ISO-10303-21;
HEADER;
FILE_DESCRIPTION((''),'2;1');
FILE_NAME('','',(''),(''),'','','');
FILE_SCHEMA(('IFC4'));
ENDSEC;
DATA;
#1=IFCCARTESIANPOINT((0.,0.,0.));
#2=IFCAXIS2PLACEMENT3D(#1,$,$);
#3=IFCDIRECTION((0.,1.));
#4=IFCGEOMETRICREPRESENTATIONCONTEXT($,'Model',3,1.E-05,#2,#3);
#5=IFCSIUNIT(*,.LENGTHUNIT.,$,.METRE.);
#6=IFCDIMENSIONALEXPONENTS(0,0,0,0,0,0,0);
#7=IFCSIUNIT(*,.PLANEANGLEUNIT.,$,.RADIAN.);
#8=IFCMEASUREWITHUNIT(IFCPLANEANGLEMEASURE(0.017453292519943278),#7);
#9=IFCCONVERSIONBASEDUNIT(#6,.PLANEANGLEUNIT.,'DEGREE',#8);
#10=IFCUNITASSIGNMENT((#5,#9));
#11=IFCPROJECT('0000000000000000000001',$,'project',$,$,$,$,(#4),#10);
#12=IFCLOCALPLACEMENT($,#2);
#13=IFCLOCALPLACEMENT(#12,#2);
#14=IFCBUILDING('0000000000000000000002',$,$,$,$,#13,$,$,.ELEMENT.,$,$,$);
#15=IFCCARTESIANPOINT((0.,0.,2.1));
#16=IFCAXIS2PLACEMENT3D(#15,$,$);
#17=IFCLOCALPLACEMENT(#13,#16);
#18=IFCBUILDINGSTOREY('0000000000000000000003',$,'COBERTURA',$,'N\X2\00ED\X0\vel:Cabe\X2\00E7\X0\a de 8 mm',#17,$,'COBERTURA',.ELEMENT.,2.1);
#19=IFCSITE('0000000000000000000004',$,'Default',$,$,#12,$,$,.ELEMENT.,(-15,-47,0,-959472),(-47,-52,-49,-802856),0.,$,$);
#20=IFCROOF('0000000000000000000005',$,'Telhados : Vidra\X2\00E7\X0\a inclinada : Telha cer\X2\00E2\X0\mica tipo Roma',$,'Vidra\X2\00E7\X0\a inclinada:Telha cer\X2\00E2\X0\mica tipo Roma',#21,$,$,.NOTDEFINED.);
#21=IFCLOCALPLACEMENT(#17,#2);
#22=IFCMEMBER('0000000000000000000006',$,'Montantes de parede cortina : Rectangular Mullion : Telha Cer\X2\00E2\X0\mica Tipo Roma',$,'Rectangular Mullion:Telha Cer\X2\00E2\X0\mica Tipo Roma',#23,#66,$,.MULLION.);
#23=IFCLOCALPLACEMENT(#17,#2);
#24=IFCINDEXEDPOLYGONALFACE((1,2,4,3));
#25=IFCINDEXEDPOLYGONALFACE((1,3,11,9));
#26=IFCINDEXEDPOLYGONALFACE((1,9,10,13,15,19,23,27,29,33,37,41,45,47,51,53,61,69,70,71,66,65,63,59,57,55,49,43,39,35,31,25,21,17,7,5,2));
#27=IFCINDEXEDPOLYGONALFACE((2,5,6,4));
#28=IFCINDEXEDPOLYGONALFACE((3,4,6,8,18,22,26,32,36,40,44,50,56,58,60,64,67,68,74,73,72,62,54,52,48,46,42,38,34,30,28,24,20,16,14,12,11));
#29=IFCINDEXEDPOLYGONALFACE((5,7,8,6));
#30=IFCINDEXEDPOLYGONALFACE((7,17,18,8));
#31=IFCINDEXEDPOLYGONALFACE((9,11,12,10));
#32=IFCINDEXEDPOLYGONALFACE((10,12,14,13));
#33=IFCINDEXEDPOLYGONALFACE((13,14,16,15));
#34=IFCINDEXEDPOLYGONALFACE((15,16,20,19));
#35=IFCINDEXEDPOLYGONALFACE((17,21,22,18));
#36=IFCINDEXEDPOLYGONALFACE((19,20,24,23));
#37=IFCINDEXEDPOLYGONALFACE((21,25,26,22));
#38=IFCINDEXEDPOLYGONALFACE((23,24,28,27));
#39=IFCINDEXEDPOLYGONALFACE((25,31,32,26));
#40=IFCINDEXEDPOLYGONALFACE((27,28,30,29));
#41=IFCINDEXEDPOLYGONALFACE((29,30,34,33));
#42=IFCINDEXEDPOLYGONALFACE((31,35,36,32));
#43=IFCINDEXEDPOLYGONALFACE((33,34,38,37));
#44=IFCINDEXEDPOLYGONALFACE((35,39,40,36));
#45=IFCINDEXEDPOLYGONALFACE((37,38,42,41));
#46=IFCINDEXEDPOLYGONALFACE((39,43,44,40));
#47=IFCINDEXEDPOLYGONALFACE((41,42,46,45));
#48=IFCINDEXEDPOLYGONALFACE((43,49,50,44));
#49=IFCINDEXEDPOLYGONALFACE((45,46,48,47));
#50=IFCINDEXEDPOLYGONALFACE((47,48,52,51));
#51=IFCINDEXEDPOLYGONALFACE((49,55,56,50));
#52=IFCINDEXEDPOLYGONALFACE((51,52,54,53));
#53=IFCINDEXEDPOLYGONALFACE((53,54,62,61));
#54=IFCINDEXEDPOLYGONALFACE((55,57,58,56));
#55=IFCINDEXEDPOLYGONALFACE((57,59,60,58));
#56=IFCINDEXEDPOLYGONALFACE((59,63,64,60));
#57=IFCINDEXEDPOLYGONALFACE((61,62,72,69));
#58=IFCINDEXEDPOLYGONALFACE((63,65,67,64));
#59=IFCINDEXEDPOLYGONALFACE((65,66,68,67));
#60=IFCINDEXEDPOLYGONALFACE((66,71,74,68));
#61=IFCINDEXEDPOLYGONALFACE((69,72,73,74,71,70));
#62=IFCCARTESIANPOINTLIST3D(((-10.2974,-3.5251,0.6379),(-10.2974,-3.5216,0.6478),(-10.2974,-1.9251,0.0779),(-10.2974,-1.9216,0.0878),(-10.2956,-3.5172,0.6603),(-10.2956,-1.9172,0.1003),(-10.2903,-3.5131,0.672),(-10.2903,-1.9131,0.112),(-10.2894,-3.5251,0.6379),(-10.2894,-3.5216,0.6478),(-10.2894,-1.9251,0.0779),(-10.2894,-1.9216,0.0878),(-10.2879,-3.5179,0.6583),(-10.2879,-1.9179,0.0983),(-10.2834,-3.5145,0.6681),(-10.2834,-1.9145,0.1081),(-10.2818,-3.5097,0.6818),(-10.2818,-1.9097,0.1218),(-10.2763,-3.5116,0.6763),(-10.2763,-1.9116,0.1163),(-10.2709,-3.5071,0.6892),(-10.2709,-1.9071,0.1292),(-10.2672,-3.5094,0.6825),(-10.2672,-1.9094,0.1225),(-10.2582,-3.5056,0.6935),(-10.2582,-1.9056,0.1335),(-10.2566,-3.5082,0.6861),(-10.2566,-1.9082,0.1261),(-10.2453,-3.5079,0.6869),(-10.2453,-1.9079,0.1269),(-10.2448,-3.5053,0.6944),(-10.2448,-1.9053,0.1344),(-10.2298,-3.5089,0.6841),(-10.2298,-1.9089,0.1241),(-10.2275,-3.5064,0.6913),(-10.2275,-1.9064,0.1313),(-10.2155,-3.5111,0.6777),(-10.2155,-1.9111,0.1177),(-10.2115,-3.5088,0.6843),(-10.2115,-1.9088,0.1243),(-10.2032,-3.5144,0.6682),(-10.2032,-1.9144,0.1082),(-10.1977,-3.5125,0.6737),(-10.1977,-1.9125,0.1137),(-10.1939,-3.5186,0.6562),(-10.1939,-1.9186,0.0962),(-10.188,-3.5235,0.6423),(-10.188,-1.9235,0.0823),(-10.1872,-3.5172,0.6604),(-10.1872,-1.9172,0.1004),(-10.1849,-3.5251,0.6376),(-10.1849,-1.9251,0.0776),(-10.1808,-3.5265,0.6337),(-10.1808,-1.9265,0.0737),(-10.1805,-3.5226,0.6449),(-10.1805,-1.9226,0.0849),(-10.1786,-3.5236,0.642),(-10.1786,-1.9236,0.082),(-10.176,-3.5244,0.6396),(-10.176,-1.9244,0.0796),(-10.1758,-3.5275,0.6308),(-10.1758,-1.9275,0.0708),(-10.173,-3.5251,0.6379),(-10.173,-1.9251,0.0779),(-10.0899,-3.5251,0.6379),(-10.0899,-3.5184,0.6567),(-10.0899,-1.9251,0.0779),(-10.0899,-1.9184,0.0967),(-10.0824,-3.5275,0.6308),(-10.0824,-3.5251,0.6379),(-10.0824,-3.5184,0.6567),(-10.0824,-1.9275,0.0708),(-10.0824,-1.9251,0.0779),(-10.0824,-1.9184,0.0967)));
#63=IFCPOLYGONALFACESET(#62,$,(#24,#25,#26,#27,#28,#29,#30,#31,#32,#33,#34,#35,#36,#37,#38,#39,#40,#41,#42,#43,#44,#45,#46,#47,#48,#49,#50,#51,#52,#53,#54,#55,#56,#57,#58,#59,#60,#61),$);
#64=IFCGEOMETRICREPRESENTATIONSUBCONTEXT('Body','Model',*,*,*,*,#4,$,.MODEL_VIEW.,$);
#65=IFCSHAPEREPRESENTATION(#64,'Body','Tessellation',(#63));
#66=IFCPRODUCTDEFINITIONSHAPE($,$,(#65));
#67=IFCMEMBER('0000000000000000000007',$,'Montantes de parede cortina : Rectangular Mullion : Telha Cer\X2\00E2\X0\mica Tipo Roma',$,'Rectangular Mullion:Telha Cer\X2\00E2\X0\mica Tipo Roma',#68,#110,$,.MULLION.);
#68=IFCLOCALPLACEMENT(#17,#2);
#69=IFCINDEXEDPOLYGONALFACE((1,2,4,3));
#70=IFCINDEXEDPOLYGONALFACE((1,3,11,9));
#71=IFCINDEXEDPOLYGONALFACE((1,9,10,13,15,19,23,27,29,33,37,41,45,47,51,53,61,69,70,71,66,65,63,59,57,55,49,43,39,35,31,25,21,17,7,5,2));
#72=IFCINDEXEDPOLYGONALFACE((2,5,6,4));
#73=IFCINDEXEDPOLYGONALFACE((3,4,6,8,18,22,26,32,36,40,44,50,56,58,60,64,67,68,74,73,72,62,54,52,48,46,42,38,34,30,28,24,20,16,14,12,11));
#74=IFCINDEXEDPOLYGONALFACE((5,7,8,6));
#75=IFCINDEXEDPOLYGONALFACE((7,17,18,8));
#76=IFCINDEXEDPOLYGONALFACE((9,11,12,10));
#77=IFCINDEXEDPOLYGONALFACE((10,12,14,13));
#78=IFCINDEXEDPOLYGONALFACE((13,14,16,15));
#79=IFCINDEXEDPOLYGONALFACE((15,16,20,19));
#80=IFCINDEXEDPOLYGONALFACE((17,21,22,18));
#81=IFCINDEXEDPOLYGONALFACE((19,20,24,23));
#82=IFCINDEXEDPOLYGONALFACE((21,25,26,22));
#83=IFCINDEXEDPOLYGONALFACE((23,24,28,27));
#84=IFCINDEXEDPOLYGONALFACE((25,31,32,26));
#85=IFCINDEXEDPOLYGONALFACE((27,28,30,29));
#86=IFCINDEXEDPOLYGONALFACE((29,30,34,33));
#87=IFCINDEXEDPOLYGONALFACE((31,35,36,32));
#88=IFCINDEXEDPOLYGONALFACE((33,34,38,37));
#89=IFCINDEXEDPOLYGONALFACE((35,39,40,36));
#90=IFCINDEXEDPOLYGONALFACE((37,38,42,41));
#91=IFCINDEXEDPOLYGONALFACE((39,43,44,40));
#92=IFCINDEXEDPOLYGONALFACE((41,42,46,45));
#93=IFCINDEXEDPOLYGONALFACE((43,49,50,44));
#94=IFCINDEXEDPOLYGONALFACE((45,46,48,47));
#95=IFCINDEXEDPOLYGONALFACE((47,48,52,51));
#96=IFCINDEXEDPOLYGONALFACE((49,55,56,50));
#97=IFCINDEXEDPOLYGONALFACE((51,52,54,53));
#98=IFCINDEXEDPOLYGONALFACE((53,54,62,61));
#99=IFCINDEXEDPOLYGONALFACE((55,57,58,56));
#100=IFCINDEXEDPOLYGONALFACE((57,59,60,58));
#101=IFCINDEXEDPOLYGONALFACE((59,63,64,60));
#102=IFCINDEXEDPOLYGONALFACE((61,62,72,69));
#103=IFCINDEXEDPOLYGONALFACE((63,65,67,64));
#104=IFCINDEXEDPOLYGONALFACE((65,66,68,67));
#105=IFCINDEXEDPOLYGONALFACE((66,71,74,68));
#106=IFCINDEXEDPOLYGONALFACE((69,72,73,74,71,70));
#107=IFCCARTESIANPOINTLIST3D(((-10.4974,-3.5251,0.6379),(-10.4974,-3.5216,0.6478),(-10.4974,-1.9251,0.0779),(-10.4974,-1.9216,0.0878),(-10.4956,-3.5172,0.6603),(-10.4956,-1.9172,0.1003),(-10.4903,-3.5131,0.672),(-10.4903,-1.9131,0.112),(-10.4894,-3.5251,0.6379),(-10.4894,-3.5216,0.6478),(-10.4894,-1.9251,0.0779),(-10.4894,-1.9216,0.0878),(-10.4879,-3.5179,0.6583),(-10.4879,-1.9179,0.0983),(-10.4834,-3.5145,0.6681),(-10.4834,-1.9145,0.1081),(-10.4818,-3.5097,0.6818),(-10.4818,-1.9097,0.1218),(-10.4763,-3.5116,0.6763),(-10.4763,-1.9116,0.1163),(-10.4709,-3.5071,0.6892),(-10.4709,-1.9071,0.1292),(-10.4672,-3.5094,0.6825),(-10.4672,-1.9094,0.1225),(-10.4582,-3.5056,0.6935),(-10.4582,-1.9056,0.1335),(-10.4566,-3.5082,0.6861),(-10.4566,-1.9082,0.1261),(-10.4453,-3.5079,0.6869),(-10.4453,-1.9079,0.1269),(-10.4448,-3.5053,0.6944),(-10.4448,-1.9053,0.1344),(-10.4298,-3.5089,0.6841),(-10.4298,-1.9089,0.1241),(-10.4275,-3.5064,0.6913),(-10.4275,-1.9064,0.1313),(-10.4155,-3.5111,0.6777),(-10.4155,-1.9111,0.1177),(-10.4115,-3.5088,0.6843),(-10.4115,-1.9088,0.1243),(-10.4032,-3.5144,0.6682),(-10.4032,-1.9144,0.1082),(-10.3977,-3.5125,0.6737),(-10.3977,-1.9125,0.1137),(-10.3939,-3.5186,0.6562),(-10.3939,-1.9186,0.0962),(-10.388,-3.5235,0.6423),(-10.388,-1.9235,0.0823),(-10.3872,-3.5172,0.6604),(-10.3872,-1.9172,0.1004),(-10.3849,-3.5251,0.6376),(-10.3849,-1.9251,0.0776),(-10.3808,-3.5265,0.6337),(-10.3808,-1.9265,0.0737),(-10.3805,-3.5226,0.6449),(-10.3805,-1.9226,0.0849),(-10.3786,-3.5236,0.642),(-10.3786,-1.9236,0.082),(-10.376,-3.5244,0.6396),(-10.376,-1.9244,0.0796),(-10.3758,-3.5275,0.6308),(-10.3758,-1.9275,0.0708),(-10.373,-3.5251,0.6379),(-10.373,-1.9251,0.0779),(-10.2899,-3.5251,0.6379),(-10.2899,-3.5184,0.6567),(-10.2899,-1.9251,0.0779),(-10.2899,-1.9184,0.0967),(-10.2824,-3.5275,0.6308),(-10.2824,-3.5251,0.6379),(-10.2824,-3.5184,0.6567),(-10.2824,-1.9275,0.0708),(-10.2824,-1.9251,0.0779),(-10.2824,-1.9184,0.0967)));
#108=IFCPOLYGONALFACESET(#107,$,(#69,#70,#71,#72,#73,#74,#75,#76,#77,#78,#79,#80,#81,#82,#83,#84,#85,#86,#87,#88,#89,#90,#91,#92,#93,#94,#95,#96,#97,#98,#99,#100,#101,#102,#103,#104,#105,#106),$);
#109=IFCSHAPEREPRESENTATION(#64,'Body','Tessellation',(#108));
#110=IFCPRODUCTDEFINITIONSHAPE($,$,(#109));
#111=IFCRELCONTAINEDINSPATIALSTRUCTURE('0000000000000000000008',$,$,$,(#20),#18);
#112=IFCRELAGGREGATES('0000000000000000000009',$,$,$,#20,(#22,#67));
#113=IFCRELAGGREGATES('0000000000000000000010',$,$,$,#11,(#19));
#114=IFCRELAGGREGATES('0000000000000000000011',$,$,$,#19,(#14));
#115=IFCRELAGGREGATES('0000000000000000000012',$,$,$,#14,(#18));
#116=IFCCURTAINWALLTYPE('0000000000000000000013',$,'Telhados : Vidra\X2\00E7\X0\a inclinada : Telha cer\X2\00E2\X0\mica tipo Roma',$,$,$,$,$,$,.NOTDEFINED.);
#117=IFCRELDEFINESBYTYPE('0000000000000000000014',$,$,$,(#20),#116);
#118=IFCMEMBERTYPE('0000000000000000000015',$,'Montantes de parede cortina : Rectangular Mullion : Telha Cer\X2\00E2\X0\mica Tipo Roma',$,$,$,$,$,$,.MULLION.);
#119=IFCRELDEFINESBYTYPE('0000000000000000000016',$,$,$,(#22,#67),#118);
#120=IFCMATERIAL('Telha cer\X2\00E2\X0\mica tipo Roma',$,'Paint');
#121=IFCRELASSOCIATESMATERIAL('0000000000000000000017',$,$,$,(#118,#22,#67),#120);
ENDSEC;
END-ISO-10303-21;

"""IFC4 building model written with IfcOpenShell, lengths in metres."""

from ifc_helpers import new_model, entity, si_unit, converted_unit, direction, frame, origin, place, context, subcontext, project, spatial, line, arc, indexed_curve, outline, extrude, source, transform, mapped, material, type_object, type_shapes, element, aggregate, save


model = new_model("IFC4")

# Units and contexts
model_context = context("Model", 3, precision=1e-05, world=origin(), true_north=direction((0.0, 1.0)))
body_context = subcontext(model_context, "Body", "Model", "MODEL_VIEW")
ifc_project = project(units=[si_unit("LENGTHUNIT", "METRE"), converted_unit("PLANEANGLEUNIT", "DEGREE", entity("IfcPlaneAngleMeasure", 0.017453292519943278), si_unit("PLANEANGLEUNIT", "RADIAN"), dimensions=[0, 0, 0, 0, 0, 0, 0])], contexts=[model_context])

# Site, building, storey
site_placement = place(None, origin())
site = spatial("IfcSite", under=ifc_project, at=site_placement, Name="Default", CompositionType="ELEMENT", RefLatitude=(-15, -47, 0, -959472), RefLongitude=(-47, -52, -49, -802856), RefElevation=0.0)
building_placement = place(site_placement, origin())
building = spatial("IfcBuilding", under=site, at=building_placement, CompositionType="ELEMENT")
storey_placement = place(building_placement, frame((0.0, 0.0, 2.1)))
storey = spatial("IfcBuildingStorey", under=building, at=storey_placement, Name="COBERTURA", ObjectType="Nível:Cabeça de 8 mm", LongName="COBERTURA", CompositionType="ELEMENT", Elevation=2.1)

# Roof, members
curtain_wall_type_1 = type_object("IfcCurtainWallType", Name="Telhados : Vidraça inclinada : Telha cerâmica tipo Roma", PredefinedType="NOTDEFINED")
roof_1_placement = place(storey_placement, frame((0.0, 0.0, -2.1)))
roof_1 = element("IfcRoof", 1, at=roof_1_placement, inside=storey, type_object=curtain_wall_type_1, Name="Telhados : Vidraça inclinada : Telha cerâmica tipo Roma", ObjectType="Vidraça inclinada:Telha cerâmica tipo Roma", PredefinedType="NOTDEFINED")
ifc_material_1 = material(Name="Telha cerâmica tipo Roma", Category="Paint")
member_type_1 = type_object("IfcMemberType", Name="Montantes de parede cortina : Rectangular Mullion : Telha Cerâmica Tipo Roma", PredefinedType="MULLION", material=ifc_material_1)
shared_shape_1 = source(origin(), body_context, "Body", "SweptSolid", [
    extrude(outline(indexed_curve([(0.0114, -0.0188), (0.1048, -0.0188), (0.1048, -0.0113), (0.1048, 0.0087), (0.0973, 0.0087), (0.0973, -0.0113), (0.0142, -0.0113), (0.0098, -0.0083), (0.0067, -0.0038), (-0.017, 0.0327), (-0.0576, 0.0486), (-0.0946, 0.0352), (-0.1102, -0.0008), (-0.1102, -0.0113), (-0.1022, -0.0113), (-0.1022, -0.0008), (-0.0891, 0.0294), (-0.0581, 0.0406), (-0.0218, 0.0263), (-0.0008, -0.0066), (0.0042, -0.0138)], segments=[line(1, 2, 3, 4, 5, 6, 7), arc(7, 8, 9), arc(9, 10, 11), arc(11, 12, 13), line(13, 14, 15, 16), arc(16, 17, 18), arc(18, 19, 20), arc(20, 21, 1)], self_intersect=False)), frame((-0.0027, -0.0938, -4.3552), z_axis=(0.0, 0.0, 1.0), x_axis=(-1.0, 0.0, 0.0)), (0.0, 0.0, 1.0), 1.6952),
])
type_shapes(member_type_1, [shared_shape_1])
member_1_placement = place(roof_1_placement, frame((-10.1899, -6.063, 3.5387), z_axis=(0.0, -0.943858, 0.33035), x_axis=(-1.0, 0.0, 0.0)))
member_1 = element("IfcMember", 2, at=member_1_placement, type_object=member_type_1, material=ifc_material_1, Name="Montantes de parede cortina : Rectangular Mullion : Telha Cerâmica Tipo Roma", ObjectType="Rectangular Mullion:Telha Cerâmica Tipo Roma", PredefinedType="MULLION", context=body_context, shape_type="MappedRepresentation", body=[
    mapped(shared_shape_1, transform((0.0, 0.0, 0.0), scale=1.0)),
])
member_2_placement = place(roof_1_placement, frame((-10.3899, -6.063, 3.5387), z_axis=(0.0, -0.943858, 0.33035), x_axis=(-1.0, 0.0, 0.0)))
member_2 = element("IfcMember", 3, at=member_2_placement, type_object=member_type_1, material=ifc_material_1, Name="Montantes de parede cortina : Rectangular Mullion : Telha Cerâmica Tipo Roma", ObjectType="Rectangular Mullion:Telha Cerâmica Tipo Roma", PredefinedType="MULLION", context=body_context, shape_type="MappedRepresentation", body=[
    mapped(shared_shape_1, transform((0.0, 0.0, 0.0), scale=1.0)),
])
aggregate(roof_1, [member_1, member_2])

save(model, "model.ifc")
